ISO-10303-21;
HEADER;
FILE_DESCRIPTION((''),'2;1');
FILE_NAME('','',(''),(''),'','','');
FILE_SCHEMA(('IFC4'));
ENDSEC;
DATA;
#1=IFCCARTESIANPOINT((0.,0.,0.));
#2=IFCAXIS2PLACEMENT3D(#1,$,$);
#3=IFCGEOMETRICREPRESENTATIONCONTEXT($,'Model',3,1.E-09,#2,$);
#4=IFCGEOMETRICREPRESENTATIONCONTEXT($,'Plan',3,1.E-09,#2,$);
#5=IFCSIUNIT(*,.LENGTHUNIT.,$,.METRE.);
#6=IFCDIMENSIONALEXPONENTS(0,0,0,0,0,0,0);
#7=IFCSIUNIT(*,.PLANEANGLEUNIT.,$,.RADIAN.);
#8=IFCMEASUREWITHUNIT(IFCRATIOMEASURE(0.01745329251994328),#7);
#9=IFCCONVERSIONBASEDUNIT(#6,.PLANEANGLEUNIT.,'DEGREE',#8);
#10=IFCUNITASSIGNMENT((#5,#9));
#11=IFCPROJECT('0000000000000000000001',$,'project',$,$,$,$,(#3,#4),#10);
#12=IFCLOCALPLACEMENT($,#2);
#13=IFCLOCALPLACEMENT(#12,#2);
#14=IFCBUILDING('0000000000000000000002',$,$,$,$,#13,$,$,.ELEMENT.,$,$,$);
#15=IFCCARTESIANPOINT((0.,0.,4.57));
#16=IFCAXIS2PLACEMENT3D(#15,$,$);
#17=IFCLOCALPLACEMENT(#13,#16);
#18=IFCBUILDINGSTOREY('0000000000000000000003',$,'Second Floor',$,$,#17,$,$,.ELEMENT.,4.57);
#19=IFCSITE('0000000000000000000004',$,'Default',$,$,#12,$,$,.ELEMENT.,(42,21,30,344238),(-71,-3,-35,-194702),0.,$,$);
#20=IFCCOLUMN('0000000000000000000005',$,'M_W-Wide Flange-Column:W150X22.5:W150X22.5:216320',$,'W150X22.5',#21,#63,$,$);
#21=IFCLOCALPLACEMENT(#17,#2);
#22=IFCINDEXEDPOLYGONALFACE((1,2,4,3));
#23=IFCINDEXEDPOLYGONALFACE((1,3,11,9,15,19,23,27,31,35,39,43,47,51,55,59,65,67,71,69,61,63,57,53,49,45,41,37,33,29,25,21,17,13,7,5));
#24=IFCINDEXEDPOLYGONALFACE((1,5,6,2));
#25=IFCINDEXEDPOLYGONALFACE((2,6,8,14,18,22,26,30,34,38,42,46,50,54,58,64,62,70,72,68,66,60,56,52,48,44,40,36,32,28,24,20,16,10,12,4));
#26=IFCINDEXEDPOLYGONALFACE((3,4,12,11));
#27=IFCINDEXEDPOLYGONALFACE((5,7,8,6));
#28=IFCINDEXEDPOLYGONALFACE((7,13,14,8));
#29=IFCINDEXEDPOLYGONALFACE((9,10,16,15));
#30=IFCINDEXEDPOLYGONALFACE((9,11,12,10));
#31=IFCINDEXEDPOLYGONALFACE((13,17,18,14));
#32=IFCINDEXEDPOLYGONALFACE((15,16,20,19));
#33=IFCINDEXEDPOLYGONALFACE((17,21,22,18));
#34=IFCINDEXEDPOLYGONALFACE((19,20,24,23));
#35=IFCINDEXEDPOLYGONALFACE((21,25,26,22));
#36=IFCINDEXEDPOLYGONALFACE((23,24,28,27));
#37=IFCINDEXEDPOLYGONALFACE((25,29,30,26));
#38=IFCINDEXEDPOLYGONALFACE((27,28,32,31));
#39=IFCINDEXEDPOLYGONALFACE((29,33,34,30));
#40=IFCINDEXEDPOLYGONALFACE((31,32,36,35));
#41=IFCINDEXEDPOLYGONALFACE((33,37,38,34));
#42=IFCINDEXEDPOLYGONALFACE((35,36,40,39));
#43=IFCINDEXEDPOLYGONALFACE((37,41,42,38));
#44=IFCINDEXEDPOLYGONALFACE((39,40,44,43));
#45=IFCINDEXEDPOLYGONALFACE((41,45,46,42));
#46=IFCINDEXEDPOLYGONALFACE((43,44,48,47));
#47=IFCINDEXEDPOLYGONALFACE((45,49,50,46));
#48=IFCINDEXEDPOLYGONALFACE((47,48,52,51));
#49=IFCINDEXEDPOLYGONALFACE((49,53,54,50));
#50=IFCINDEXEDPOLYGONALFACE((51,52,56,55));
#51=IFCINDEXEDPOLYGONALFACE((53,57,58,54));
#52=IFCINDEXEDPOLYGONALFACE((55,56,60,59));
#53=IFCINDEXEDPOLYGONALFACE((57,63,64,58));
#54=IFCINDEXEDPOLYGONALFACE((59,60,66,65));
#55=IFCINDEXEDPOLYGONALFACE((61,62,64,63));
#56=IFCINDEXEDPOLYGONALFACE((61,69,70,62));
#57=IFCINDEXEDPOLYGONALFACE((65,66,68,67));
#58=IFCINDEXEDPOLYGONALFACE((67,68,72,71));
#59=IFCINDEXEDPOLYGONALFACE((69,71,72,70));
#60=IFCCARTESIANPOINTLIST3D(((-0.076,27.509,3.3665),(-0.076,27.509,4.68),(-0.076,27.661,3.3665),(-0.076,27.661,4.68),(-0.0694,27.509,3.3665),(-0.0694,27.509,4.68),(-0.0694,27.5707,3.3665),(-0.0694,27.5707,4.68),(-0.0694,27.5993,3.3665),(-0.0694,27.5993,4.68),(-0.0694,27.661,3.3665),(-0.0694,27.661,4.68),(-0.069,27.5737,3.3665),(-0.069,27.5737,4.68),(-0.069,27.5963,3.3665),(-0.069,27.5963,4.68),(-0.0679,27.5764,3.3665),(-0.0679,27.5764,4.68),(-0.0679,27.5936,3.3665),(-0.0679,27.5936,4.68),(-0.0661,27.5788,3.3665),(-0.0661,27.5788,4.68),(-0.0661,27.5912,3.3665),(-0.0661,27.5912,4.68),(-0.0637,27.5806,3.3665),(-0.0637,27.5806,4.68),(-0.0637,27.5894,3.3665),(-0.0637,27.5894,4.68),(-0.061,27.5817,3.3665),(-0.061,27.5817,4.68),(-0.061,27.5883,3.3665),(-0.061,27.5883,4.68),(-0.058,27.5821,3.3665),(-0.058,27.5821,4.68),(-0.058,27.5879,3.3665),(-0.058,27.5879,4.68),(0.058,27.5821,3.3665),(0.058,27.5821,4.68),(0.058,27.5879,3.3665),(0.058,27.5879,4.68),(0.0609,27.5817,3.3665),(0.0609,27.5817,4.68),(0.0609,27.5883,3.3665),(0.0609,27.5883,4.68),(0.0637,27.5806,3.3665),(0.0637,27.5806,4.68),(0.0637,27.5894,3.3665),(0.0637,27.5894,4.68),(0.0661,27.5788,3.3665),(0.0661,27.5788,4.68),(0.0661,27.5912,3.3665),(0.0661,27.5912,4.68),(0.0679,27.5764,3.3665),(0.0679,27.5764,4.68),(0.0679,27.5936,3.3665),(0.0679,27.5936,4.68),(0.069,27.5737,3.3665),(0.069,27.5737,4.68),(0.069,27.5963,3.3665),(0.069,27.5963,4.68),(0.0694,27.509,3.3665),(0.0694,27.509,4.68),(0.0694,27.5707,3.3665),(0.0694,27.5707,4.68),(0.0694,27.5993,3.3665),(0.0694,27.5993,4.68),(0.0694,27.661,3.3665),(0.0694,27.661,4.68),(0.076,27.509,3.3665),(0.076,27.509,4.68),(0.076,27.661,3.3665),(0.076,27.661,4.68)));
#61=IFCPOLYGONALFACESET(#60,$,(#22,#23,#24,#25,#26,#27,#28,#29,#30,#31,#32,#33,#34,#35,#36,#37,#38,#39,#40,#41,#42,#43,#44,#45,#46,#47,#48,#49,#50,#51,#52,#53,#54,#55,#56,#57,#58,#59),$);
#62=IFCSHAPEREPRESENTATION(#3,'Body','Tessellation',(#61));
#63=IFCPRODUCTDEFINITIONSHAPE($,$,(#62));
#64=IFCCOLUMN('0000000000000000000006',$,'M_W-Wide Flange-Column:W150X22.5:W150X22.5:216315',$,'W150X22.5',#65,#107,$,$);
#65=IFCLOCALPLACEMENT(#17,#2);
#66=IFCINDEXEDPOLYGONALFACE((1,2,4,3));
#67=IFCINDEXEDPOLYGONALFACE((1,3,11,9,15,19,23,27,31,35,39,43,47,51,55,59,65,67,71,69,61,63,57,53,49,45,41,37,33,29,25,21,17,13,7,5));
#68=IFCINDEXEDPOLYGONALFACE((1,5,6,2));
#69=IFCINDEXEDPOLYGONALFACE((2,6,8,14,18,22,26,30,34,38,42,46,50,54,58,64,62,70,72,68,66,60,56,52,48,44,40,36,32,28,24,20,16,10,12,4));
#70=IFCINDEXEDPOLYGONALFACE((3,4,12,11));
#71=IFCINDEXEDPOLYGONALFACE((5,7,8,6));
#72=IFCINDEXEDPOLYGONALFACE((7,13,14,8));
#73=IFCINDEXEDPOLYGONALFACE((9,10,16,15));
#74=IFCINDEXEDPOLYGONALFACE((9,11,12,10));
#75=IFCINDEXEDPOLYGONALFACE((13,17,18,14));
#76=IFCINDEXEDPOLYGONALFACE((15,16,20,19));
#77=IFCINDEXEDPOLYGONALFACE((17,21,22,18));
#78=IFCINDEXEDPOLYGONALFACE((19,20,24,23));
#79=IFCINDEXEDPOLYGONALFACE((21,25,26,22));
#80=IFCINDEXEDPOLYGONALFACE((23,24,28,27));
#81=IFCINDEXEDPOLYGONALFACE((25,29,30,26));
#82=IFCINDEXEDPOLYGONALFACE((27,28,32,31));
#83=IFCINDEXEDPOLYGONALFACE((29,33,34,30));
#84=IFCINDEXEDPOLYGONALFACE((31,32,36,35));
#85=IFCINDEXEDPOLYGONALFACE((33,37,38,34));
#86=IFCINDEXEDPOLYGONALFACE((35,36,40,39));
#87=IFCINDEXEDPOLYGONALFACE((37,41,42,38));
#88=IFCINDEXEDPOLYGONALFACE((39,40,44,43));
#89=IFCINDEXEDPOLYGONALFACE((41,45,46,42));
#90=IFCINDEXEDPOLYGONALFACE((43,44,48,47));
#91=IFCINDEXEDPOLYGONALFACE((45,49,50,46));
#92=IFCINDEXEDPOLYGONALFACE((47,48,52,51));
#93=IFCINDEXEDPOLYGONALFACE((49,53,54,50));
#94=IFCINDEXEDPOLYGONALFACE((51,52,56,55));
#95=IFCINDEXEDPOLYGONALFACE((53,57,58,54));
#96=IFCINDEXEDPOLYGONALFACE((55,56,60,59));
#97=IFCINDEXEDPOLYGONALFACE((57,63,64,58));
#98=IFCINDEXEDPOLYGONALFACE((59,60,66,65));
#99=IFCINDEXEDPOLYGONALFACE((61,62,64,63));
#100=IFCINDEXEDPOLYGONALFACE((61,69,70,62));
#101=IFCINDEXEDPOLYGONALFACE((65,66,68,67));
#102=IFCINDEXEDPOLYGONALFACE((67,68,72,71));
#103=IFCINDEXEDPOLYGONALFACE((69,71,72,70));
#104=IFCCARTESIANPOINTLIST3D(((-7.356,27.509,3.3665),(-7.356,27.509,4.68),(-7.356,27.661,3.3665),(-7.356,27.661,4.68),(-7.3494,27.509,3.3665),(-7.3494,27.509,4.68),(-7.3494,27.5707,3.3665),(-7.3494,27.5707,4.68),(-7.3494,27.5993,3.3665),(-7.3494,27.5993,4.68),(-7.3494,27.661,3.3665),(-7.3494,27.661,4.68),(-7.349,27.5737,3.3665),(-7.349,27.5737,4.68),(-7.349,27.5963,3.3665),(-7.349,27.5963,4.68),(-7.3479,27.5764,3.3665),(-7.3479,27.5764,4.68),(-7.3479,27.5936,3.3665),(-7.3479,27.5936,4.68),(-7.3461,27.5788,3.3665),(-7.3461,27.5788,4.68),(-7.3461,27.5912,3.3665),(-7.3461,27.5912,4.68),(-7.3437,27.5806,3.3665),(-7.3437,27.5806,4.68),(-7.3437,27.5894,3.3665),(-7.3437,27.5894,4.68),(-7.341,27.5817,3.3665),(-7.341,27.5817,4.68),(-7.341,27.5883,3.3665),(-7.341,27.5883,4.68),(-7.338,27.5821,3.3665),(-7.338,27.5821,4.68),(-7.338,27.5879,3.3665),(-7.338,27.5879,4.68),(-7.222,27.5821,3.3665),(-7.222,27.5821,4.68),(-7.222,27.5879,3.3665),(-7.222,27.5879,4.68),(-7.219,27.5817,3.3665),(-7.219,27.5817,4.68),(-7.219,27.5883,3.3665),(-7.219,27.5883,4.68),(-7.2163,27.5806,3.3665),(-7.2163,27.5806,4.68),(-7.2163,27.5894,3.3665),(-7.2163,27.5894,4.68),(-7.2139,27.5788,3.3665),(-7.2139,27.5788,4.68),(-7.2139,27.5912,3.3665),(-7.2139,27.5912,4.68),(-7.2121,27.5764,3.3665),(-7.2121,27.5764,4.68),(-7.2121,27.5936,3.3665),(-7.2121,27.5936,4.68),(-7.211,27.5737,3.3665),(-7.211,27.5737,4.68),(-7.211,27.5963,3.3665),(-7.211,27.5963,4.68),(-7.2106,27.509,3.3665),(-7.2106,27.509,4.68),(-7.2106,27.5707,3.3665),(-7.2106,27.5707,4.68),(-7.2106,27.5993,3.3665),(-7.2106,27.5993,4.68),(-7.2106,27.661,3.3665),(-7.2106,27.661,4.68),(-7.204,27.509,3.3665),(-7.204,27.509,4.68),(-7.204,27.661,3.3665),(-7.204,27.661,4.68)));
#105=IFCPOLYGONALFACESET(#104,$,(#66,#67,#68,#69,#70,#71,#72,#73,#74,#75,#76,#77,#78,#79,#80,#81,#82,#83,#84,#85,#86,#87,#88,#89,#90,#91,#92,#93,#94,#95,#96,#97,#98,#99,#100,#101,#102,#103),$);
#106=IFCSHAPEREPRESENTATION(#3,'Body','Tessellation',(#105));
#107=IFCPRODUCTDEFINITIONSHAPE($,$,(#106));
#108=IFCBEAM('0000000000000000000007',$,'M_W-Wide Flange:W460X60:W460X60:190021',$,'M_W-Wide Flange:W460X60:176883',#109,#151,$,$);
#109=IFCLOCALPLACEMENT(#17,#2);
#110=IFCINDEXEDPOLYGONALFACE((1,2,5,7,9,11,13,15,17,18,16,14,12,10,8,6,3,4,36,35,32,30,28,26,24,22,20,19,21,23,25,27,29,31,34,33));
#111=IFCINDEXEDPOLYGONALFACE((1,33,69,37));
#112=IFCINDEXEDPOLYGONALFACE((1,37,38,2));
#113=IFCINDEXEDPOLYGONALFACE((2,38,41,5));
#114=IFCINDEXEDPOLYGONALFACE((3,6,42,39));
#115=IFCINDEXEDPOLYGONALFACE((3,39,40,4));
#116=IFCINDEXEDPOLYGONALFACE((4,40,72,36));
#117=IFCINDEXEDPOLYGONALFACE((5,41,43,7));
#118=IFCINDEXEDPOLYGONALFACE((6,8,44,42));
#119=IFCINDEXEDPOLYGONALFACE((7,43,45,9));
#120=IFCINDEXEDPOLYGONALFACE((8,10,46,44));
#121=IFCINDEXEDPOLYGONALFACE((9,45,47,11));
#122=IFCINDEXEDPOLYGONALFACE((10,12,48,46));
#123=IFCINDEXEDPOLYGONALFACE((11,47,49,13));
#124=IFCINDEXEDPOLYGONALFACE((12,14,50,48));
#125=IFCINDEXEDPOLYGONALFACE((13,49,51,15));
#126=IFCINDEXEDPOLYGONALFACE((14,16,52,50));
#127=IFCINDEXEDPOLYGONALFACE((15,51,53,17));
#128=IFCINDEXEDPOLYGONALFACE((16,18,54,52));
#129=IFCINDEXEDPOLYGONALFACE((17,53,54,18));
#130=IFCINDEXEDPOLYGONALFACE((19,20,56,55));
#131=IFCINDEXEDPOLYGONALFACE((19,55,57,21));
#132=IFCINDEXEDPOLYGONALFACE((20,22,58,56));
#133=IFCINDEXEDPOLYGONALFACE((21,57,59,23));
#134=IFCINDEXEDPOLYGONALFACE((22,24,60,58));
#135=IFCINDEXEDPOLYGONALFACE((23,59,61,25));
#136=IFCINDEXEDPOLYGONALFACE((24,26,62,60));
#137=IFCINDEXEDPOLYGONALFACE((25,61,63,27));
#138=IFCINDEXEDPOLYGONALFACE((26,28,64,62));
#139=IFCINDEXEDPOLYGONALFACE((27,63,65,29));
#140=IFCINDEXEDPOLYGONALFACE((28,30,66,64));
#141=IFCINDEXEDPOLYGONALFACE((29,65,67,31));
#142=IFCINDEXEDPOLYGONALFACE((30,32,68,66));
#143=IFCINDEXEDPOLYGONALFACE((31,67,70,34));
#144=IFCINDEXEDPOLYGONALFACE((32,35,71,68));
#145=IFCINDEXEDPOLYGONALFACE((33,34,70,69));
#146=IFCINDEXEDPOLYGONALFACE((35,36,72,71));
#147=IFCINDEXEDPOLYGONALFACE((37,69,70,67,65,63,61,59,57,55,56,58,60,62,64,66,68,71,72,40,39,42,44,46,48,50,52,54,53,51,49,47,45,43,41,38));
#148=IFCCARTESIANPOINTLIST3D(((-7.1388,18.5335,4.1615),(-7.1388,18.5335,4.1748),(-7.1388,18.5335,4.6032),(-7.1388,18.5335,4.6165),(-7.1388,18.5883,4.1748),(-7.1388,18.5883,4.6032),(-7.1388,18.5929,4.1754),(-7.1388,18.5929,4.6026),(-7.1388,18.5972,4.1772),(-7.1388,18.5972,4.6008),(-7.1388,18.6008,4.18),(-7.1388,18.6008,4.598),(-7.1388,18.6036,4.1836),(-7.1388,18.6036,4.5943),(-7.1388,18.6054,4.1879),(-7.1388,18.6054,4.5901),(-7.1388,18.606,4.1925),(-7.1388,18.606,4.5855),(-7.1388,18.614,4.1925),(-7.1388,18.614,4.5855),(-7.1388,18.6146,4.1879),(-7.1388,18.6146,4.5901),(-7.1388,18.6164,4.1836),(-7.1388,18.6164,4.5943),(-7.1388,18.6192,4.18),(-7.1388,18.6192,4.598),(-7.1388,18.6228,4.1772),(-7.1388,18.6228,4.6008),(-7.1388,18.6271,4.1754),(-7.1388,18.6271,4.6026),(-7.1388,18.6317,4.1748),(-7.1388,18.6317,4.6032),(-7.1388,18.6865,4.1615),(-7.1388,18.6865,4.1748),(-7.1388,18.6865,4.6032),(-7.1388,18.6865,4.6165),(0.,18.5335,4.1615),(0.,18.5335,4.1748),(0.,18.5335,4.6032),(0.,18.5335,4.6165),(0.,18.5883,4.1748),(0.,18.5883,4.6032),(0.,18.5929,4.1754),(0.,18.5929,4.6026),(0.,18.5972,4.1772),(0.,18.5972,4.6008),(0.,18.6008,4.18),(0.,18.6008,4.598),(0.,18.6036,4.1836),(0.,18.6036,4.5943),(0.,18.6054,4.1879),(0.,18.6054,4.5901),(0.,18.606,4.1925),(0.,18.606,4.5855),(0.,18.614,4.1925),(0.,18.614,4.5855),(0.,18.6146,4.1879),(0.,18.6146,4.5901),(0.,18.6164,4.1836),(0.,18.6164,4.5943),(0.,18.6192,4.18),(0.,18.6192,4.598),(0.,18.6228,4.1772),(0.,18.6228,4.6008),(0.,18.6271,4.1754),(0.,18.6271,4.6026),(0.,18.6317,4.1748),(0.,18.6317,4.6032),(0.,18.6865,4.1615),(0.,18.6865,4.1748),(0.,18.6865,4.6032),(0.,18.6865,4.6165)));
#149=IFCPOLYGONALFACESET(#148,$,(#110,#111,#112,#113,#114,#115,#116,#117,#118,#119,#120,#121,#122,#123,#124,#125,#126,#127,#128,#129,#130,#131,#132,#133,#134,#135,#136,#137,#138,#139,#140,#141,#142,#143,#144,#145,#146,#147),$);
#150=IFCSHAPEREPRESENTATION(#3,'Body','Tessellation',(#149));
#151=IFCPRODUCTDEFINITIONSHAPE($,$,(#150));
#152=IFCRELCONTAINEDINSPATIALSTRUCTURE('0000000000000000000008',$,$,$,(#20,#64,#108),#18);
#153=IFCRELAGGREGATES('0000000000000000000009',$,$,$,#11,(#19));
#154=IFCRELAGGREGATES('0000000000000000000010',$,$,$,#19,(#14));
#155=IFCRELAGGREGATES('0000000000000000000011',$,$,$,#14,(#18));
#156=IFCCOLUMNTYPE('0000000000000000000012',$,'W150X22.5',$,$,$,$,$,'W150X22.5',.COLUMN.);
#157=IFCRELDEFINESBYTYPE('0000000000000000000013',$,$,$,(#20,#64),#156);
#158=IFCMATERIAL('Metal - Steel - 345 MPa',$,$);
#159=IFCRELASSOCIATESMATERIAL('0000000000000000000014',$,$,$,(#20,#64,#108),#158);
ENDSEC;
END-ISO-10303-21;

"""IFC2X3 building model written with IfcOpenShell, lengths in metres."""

from ifc_helpers import new_model, entity, si_unit, converted_unit, frame, frame_2d, origin, place, context, project, spatial, polyline, circle_curve, parameter, trimmed, segment, composite_curve, outline, extrude, source, transform, mapped, material, type_object, type_shapes, element, save


model = new_model("IFC2X3")

# Units and contexts
model_context = context("Model", 3, precision=1e-09, world=origin())
plan_context = context("Plan", 3, precision=1e-09, world=origin())
ifc_project = project(units=[si_unit("LENGTHUNIT", "METRE"), converted_unit("PLANEANGLEUNIT", "DEGREE", entity("IfcRatioMeasure", 0.01745329251994328), si_unit("PLANEANGLEUNIT", "RADIAN"), dimensions=[0, 0, 0, 0, 0, 0, 0])], contexts=[model_context, plan_context])

# Site, building, storey
site_placement = place(None, origin())
site = spatial("IfcSite", under=ifc_project, at=site_placement, Name="Default", CompositionType="ELEMENT", RefLatitude=(42, 21, 30, 344238), RefLongitude=(-71, -3, -35, -194702), RefElevation=0.0)
building_placement = place(site_placement, origin())
building = spatial("IfcBuilding", under=site, at=building_placement, CompositionType="ELEMENT")
storey_placement = place(building_placement, frame((0.0, 0.0, 4.57)))
storey = spatial("IfcBuildingStorey", under=building, at=storey_placement, Name="Second Floor", CompositionType="ELEMENT", Elevation=4.57)

# Columns
ifc_material = material(Name="Metal - Steel - 345 MPa")
column_type_1 = type_object("IfcColumnType", Name="W150X22.5", ElementType="W150X22.5", PredefinedType="COLUMN")
shared_shape_1 = source(origin(), model_context, "Body", "SweptSolid", [
    extrude(outline(composite_curve([segment(polyline([(-0.076, -0.076), (-0.0694, -0.076)]), True, "CONTINUOUS"), segment(polyline([(-0.0694, -0.076), (-0.0694, -0.0143)]), True, "CONTINUOUS"), segment(trimmed(circle_curve(frame_2d((-0.058, -0.0143), x_axis=(0.0, -1.0)), 0.0114), [parameter(180.0)], [parameter(270.0)], True, "PARAMETER"), False, "CONTINUOUS"), segment(polyline([(-0.058, -0.0029), (0.058, -0.0029)]), True, "CONTINUOUS"), segment(trimmed(circle_curve(frame_2d((0.058, -0.0143), x_axis=(0.0, -1.0)), 0.0114), [parameter(90.0)], [parameter(180.0)], True, "PARAMETER"), False, "CONTINUOUS"), segment(polyline([(0.0694, -0.0143), (0.0694, -0.076)]), True, "CONTINUOUS"), segment(polyline([(0.0694, -0.076), (0.076, -0.076)]), True, "CONTINUOUS"), segment(polyline([(0.076, -0.076), (0.076, 0.076)]), True, "CONTINUOUS"), segment(polyline([(0.076, 0.076), (0.0694, 0.076)]), True, "CONTINUOUS"), segment(polyline([(0.0694, 0.076), (0.0694, 0.0143)]), True, "CONTINUOUS"), segment(trimmed(circle_curve(frame_2d((0.058, 0.0143), x_axis=(0.0, -1.0)), 0.0114), [parameter(360.0)], [parameter(90.0)], True, "PARAMETER"), False, "CONTINUOUS"), segment(polyline([(0.058, 0.0029), (-0.058, 0.0029)]), True, "CONTINUOUS"), segment(trimmed(circle_curve(frame_2d((-0.058, 0.0143), x_axis=(0.0, -1.0)), 0.0114), [parameter(270.0)], [parameter(360.0)], True, "PARAMETER"), False, "CONTINUOUS"), segment(polyline([(-0.0694, 0.0143), (-0.0694, 0.076)]), True, "CONTINUOUS"), segment(polyline([(-0.0694, 0.076), (-0.076, 0.076)]), True, "CONTINUOUS"), segment(polyline([(-0.076, 0.076), (-0.076, -0.076)]), True, "CONTINUOUS")], self_intersect=False)), frame((0.0, 0.0, 7.9365), z_axis=(0.0, 0.0, 1.0), x_axis=(0.0, 1.0, 0.0)), (0.0, 0.0, 1.0), 1.3135),
])
type_shapes(column_type_1, [shared_shape_1])
for number, where, z_axis, x_axis, name in (
    (1, (0.0, 27.585, -4.57), (0.0, 0.0, 1.0), (0.0, -1.0, 0.0), "M_W-Wide Flange-Column:W150X22.5:W150X22.5:216320"),
    (2, (-7.28, 27.585, -4.57), (0.0, 0.0, 1.0), (0.0, -1.0, 0.0), "M_W-Wide Flange-Column:W150X22.5:W150X22.5:216315"),
):
    element("IfcColumn", number, at=place(storey_placement, frame(where, z_axis=z_axis, x_axis=x_axis)), inside=storey, type_object=column_type_1, material=ifc_material, Name=name, ObjectType="W150X22.5", context=model_context, shape_type="MappedRepresentation", body=[
        mapped(shared_shape_1, transform((0.0, 0.0, 0.0), scale=1.0)),
    ])

# Beam
beam_1_placement = place(storey_placement, frame((-7.2774, 18.61, 4.6165), z_axis=(0.0, 0.0, 1.0), x_axis=(0.0, -1.0, 0.0)))
element("IfcBeam", 3, at=beam_1_placement, inside=storey, material=ifc_material, Name="M_W-Wide Flange:W460X60:W460X60:190021", ObjectType="M_W-Wide Flange:W460X60:176883", context=model_context, shape_type="SweptSolid", body=[
    extrude(outline(composite_curve([segment(polyline([(-0.0765, -0.2142), (-0.0765, -0.2275)]), True, "CONTINUOUS"), segment(polyline([(-0.0765, -0.2275), (0.0765, -0.2275)]), True, "CONTINUOUS"), segment(polyline([(0.0765, -0.2275), (0.0765, -0.2142)]), True, "CONTINUOUS"), segment(polyline([(0.0765, -0.2142), (0.0217, -0.2142)]), True, "CONTINUOUS"), segment(trimmed(circle_curve(frame_2d((0.0217, -0.1965), x_axis=(1.0, 0.0)), 0.0177), [parameter(180.0)], [parameter(270.0)], True, "PARAMETER"), False, "CONTINUOUS"), segment(polyline([(0.004, -0.1965), (0.004, 0.1965)]), True, "CONTINUOUS"), segment(trimmed(circle_curve(frame_2d((0.0217, 0.1965), x_axis=(1.0, 0.0)), 0.0177), [parameter(90.0)], [parameter(180.0)], True, "PARAMETER"), False, "CONTINUOUS"), segment(polyline([(0.0217, 0.2142), (0.0765, 0.2142)]), True, "CONTINUOUS"), segment(polyline([(0.0765, 0.2142), (0.0765, 0.2275)]), True, "CONTINUOUS"), segment(polyline([(0.0765, 0.2275), (-0.0765, 0.2275)]), True, "CONTINUOUS"), segment(polyline([(-0.0765, 0.2275), (-0.0765, 0.2142)]), True, "CONTINUOUS"), segment(polyline([(-0.0765, 0.2142), (-0.0217, 0.2142)]), True, "CONTINUOUS"), segment(trimmed(circle_curve(frame_2d((-0.0217, 0.1965), x_axis=(1.0, 0.0)), 0.0177), [parameter(360.0)], [parameter(90.0)], True, "PARAMETER"), False, "CONTINUOUS"), segment(polyline([(-0.004, 0.1965), (-0.004, -0.1965)]), True, "CONTINUOUS"), segment(trimmed(circle_curve(frame_2d((-0.0217, -0.1965), x_axis=(1.0, 0.0)), 0.0177), [parameter(270.0)], [parameter(0.0)], True, "PARAMETER"), False, "CONTINUOUS"), segment(polyline([(-0.0217, -0.2142), (-0.0765, -0.2142)]), True, "CONTINUOUS")], self_intersect=False)), frame((0.0, 0.1386, -0.2275), z_axis=(0.0, -1.0, 0.0), x_axis=(1.0, 0.0, 0.0)), (0.0, 0.0, -1.0), 7.1388),
])

save(model, "model.ifc")
